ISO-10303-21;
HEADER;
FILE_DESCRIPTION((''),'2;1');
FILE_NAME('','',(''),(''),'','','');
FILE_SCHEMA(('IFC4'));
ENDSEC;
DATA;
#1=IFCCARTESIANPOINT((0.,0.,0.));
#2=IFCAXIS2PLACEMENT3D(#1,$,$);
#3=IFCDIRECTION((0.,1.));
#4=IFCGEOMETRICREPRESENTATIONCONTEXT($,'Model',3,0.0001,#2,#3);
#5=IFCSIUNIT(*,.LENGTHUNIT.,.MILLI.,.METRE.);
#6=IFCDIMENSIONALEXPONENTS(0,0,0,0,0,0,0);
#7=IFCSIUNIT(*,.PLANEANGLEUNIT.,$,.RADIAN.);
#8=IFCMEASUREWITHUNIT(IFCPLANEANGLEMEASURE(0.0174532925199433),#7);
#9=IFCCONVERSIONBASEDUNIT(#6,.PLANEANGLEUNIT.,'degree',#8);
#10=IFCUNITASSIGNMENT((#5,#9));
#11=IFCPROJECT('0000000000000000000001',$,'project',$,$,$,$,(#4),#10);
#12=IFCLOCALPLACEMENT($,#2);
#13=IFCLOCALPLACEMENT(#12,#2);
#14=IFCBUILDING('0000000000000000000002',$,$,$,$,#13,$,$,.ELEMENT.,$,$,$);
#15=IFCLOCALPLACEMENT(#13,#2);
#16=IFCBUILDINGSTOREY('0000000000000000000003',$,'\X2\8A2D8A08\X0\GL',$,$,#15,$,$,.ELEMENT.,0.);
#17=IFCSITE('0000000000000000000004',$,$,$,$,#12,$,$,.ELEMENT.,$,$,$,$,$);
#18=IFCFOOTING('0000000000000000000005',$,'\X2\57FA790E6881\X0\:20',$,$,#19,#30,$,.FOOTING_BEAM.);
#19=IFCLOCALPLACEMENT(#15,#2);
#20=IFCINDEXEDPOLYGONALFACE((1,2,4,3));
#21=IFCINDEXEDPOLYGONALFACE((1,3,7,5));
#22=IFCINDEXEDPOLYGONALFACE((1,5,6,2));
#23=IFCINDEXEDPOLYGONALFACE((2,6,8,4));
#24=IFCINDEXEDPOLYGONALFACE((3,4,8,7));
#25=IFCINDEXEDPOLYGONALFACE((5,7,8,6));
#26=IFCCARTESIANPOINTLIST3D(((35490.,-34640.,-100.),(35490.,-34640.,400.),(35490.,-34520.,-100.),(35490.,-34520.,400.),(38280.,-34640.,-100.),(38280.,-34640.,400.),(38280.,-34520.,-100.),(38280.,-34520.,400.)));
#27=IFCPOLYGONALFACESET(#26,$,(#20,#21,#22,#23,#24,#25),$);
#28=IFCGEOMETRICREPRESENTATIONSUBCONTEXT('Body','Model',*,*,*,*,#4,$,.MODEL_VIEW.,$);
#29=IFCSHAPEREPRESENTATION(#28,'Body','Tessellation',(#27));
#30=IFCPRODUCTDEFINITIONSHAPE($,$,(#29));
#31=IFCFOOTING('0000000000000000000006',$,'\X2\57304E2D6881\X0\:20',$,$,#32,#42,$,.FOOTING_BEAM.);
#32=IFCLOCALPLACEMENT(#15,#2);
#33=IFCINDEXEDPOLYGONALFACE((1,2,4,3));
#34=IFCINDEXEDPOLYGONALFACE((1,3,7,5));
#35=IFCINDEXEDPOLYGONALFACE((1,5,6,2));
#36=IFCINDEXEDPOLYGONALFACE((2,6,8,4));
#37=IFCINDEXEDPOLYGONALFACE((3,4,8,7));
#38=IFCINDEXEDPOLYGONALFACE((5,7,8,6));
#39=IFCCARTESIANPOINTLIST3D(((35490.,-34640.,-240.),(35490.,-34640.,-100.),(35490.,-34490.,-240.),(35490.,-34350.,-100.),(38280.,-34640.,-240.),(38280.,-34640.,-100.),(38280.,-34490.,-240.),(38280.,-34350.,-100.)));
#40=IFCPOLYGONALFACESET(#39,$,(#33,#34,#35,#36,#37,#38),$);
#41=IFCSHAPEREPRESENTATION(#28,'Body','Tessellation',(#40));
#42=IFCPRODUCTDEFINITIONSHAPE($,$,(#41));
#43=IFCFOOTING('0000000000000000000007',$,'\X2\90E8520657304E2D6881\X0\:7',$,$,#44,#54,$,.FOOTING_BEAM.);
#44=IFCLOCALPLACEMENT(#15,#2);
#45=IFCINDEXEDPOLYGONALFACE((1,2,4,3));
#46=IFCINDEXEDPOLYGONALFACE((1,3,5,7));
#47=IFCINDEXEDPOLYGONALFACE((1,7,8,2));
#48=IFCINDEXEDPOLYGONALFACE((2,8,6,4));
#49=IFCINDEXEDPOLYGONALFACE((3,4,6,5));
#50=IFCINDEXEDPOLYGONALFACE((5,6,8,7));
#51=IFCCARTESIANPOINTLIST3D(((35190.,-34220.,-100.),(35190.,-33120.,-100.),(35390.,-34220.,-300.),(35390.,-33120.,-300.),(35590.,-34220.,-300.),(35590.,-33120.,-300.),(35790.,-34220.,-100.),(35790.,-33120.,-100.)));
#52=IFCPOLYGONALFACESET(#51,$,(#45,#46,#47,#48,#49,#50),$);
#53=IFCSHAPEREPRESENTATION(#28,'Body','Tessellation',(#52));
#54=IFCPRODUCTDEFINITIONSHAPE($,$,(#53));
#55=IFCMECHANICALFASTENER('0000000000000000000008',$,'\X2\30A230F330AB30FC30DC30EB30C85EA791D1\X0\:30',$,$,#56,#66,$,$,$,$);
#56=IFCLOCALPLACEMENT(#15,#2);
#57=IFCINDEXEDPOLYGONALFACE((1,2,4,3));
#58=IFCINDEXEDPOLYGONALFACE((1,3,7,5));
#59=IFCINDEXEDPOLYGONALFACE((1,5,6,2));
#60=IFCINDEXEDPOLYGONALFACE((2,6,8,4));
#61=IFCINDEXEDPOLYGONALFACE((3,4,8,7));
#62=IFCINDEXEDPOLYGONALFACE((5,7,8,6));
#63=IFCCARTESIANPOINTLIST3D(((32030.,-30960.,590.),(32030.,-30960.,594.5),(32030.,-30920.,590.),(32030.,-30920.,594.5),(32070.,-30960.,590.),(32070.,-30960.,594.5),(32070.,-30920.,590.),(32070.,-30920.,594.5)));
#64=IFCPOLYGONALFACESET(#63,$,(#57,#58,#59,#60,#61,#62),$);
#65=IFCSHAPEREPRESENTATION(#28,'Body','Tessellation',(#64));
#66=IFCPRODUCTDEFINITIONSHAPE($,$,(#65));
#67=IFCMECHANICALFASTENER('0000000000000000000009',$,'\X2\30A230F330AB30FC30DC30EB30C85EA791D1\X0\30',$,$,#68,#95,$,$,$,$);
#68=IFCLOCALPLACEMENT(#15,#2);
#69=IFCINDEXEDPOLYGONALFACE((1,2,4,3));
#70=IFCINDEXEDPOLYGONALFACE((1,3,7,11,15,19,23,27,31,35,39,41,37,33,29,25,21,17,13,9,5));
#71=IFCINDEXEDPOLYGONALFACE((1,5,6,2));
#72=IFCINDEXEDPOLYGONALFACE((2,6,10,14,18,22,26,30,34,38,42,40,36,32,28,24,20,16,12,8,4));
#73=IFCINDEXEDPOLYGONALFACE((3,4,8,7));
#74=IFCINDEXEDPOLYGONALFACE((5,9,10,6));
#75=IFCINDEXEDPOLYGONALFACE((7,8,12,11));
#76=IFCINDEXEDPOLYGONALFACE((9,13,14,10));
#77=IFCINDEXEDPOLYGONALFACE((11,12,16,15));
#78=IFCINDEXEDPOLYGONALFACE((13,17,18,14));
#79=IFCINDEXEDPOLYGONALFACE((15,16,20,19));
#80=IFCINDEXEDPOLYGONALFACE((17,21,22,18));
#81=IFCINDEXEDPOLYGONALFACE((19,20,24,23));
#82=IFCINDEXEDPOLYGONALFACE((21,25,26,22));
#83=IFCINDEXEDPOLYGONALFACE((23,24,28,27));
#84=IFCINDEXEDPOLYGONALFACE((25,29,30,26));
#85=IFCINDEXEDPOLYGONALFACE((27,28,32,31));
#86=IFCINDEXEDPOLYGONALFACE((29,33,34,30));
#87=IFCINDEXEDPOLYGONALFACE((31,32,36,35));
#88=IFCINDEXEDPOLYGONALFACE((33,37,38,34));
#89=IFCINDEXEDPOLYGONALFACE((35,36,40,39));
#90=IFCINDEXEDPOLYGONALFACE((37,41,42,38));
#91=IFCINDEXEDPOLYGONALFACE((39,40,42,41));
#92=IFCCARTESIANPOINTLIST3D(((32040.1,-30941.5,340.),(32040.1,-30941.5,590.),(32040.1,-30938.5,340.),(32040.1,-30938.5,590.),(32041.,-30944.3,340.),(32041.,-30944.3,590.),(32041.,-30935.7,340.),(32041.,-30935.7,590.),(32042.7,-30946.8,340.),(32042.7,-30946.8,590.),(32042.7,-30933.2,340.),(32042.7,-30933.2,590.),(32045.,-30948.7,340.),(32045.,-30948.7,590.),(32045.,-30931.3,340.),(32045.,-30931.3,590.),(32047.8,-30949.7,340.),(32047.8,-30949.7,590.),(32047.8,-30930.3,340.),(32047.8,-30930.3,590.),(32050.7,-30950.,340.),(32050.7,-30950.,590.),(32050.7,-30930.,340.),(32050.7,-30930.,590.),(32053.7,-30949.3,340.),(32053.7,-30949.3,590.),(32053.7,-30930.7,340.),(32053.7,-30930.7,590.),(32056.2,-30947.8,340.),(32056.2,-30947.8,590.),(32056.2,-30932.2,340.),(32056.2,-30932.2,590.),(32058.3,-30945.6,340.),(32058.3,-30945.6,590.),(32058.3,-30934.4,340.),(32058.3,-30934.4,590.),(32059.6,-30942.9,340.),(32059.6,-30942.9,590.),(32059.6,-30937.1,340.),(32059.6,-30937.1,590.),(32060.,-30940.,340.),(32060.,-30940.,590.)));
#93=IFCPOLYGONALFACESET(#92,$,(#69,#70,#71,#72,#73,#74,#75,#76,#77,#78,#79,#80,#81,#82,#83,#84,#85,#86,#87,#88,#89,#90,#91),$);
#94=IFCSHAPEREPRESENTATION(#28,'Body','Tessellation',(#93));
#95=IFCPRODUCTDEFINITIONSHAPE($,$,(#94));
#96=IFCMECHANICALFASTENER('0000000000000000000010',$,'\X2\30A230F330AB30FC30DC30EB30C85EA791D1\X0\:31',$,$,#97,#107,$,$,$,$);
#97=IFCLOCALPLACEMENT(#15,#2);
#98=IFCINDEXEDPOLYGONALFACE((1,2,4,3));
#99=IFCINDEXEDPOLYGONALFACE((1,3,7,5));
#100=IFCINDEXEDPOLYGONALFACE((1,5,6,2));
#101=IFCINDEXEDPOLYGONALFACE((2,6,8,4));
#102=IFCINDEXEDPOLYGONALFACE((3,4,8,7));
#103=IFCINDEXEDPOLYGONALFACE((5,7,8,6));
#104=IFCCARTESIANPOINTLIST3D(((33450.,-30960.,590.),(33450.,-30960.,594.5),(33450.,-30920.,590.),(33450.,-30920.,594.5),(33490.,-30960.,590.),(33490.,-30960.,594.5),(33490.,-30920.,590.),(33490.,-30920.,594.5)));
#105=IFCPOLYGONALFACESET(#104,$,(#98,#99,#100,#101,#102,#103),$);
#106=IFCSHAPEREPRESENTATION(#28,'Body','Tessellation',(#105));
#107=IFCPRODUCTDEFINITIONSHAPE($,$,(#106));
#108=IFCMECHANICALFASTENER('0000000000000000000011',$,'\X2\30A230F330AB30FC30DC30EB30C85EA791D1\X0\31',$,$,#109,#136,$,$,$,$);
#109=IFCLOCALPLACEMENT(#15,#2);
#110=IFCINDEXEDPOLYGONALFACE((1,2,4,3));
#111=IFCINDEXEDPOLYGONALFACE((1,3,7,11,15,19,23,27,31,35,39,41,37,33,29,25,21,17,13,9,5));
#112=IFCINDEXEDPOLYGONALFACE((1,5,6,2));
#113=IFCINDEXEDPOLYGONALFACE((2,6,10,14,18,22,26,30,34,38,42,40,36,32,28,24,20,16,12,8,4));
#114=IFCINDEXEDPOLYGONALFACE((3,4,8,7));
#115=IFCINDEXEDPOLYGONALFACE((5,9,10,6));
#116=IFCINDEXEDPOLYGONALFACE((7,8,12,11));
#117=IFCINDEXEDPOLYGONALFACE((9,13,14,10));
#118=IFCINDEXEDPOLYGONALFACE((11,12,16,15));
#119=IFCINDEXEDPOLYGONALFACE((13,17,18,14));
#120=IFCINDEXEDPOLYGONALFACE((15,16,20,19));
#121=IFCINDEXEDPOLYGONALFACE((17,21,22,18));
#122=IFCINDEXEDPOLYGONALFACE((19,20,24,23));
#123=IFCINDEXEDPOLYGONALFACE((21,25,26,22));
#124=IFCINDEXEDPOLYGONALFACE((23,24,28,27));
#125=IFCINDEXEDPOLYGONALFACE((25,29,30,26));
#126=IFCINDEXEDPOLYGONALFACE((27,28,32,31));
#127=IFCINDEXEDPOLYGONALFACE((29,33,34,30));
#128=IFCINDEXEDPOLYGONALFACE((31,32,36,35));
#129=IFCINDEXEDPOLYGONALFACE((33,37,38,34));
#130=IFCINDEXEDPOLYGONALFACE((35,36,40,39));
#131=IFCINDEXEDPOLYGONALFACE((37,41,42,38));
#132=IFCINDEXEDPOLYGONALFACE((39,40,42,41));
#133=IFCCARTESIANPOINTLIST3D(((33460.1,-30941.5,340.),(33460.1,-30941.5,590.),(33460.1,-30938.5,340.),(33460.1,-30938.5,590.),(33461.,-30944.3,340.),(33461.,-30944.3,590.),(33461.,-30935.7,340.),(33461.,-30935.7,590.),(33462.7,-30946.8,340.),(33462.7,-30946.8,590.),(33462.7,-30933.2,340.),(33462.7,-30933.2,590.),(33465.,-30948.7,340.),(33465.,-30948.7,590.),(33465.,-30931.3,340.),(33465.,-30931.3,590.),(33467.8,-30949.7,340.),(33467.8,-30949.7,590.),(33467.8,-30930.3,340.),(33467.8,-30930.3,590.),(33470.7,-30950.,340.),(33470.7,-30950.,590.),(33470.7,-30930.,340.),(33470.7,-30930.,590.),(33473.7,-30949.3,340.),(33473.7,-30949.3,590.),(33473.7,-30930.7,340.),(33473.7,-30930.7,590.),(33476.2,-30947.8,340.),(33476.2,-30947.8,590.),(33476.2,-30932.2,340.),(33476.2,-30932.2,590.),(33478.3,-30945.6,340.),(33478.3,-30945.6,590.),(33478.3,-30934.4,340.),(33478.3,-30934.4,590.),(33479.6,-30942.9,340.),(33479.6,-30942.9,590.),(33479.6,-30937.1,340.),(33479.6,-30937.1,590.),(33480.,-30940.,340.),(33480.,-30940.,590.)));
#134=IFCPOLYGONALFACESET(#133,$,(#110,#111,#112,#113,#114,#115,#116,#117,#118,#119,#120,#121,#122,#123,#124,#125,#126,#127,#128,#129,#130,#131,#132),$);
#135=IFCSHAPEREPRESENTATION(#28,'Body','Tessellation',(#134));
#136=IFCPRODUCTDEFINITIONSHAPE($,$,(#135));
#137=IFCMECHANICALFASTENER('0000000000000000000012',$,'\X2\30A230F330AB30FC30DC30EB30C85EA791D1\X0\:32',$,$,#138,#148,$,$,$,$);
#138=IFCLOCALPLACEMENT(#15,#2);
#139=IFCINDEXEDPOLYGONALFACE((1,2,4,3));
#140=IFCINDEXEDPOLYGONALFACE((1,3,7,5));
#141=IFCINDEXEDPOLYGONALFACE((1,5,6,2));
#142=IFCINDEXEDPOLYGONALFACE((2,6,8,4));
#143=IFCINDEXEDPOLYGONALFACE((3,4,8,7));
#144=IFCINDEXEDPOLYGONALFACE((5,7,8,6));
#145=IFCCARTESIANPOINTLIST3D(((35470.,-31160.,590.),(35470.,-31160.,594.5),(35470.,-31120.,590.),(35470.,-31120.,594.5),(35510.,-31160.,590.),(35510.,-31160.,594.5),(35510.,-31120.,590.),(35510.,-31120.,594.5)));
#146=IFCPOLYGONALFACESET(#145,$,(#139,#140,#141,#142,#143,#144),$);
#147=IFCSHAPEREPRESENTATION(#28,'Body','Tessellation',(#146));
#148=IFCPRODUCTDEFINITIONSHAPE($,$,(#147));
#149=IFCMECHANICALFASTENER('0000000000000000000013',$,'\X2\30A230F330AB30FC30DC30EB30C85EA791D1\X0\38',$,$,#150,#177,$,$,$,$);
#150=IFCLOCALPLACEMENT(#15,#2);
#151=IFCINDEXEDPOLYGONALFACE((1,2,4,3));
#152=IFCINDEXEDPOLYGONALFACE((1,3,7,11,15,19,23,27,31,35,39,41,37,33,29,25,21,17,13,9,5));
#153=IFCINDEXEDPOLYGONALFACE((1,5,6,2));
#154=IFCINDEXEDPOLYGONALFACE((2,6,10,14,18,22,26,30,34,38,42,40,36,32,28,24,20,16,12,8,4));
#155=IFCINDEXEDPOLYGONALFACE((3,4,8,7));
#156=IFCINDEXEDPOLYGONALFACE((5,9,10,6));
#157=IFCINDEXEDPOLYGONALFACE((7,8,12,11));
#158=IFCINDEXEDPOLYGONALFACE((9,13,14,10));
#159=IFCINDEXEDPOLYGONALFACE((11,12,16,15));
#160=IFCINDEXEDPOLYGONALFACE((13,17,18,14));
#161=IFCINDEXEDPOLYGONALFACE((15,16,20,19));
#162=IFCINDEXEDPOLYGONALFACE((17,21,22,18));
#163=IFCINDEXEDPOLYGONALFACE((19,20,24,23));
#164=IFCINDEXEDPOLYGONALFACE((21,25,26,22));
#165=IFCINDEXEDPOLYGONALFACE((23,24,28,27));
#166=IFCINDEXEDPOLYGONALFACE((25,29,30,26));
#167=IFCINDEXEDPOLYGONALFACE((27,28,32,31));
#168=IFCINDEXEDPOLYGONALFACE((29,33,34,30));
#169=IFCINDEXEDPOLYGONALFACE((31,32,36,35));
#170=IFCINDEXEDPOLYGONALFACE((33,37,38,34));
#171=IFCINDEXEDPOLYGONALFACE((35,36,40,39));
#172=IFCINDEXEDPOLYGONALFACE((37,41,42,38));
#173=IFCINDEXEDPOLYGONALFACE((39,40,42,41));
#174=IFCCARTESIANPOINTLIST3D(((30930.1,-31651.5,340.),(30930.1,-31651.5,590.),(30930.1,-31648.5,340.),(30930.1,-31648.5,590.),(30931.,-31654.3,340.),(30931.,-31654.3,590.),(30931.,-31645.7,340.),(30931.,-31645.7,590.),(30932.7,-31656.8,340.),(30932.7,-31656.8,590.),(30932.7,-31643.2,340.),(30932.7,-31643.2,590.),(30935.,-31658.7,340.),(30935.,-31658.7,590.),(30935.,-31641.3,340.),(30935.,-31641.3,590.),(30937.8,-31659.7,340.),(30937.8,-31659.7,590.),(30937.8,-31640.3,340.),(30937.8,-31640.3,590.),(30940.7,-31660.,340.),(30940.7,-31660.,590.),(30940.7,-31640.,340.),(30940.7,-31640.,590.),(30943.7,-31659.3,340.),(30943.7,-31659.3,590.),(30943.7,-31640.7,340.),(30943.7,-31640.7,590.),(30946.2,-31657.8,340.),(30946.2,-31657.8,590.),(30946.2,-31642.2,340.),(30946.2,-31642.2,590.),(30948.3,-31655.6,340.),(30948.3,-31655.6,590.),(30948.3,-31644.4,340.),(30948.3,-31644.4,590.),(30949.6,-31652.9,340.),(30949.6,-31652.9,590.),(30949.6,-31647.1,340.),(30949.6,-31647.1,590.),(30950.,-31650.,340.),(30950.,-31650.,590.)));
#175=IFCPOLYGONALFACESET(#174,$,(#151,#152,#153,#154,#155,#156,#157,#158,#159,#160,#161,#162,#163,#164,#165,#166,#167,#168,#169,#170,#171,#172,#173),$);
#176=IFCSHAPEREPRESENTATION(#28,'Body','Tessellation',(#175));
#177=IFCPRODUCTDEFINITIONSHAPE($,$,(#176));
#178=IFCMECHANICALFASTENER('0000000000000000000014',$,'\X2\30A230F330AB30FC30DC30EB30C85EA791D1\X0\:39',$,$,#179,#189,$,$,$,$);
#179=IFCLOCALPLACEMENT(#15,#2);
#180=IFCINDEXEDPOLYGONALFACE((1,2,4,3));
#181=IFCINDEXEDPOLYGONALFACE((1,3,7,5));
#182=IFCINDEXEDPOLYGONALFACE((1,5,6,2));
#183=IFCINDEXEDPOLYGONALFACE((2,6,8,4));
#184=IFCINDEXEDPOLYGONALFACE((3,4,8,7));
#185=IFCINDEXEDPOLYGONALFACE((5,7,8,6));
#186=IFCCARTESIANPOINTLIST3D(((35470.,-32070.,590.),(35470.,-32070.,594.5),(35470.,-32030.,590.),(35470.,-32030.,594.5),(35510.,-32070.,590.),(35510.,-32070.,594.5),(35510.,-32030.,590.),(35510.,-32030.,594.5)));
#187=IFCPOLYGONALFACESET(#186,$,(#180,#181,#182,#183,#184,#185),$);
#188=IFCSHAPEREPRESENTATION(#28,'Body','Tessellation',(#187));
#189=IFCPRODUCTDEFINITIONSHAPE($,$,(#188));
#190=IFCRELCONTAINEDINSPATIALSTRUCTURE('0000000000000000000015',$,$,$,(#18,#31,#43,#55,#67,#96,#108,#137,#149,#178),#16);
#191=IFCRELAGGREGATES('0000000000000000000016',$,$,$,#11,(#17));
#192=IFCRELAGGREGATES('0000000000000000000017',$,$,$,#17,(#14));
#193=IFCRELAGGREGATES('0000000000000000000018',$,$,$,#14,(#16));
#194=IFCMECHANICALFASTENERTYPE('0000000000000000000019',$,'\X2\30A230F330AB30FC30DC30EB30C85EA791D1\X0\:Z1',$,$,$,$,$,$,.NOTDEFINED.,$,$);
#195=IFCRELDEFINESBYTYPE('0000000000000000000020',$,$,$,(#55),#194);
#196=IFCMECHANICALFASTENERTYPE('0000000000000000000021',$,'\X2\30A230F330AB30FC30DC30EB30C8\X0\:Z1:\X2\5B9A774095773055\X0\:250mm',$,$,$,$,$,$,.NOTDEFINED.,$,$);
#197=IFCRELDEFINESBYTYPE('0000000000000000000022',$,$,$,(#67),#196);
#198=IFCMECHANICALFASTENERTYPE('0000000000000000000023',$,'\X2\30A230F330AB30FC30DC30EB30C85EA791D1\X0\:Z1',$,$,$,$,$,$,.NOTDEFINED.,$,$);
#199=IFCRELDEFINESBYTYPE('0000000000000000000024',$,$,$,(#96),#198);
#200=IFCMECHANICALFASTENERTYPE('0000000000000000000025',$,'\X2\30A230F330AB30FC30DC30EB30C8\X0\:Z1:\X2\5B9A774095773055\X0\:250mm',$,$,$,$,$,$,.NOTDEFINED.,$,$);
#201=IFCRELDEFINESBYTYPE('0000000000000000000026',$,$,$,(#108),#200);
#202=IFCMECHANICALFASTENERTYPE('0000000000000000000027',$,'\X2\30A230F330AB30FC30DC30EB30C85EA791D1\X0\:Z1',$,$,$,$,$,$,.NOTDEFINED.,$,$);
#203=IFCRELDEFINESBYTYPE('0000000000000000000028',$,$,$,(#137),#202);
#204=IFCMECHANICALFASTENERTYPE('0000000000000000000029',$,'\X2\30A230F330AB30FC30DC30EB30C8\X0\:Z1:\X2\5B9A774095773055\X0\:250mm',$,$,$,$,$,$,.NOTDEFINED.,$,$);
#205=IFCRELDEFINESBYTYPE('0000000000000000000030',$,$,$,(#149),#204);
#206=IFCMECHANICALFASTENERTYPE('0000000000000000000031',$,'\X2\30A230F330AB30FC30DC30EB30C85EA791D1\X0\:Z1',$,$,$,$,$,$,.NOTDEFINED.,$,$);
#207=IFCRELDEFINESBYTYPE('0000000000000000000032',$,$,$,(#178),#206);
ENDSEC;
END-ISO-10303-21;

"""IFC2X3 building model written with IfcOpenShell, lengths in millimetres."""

from ifc_helpers import new_model, entity, si_unit, converted_unit, direction, frame, origin, origin_with_axes, origin_2d, place, context, subcontext, project, spatial, polyline, rectangle, circle, outline, extrude, type_object, element, save


model = new_model("IFC2X3")

# Units and contexts
model_context = context("Model", 3, precision=0.0001, world=origin(), true_north=direction((0.0, 1.0)))
body_context = subcontext(model_context, "Body", "Model", "MODEL_VIEW")
ifc_project = project(units=[si_unit("LENGTHUNIT", "METRE", prefix="MILLI"), converted_unit("PLANEANGLEUNIT", "degree", entity("IfcPlaneAngleMeasure", 0.0174532925199433), si_unit("PLANEANGLEUNIT", "RADIAN"), dimensions=[0, 0, 0, 0, 0, 0, 0])], contexts=[model_context])

# Site, building, storey
site_placement = place(None, origin())
site = spatial("IfcSite", under=ifc_project, at=site_placement, CompositionType="ELEMENT")
building_placement = place(site_placement, origin())
building = spatial("IfcBuilding", under=site, at=building_placement, CompositionType="ELEMENT")
storey_placement = place(building_placement, origin())
storey = spatial("IfcBuildingStorey", under=building, at=storey_placement, Name="設計GL", CompositionType="ELEMENT", Elevation=0.0)

# Footings
footing_1_placement = place(storey_placement, frame((35490.0, -34580.0, 150.0), z_axis=(1.0, 0.0, 0.0), x_axis=(0.0, 1.0, 0.0)))
element("IfcFooting", 1, at=footing_1_placement, inside=storey, Name="基礎梁:20", PredefinedType="FOOTING_BEAM", context=body_context, shape_type="SolidModel", body=[
    extrude(rectangle(XDim=120.0, YDim=500.0, at=origin_2d()), origin_with_axes(), (0.0, 0.0, 1.0), 2790.0),
])
footing_2_placement = place(storey_placement, frame((35490.0, -34640.0, -240.0), z_axis=(1.0, 0.0, 0.0), x_axis=(0.0, 1.0, 0.0)))
element("IfcFooting", 2, at=footing_2_placement, inside=storey, Name="地中梁:20", PredefinedType="FOOTING_BEAM", context=body_context, shape_type="SweptSolid", body=[
    extrude(outline(polyline([(0.0, 0.0, 0.0), (150.0, 0.0, 0.0), (290.0, 140.0, 0.0), (0.0, 140.0, 0.0), (0.0, 0.0, 0.0)])), origin_with_axes(), (0.0, 0.0, 1.0), 2790.0),
])
footing_3_placement = place(storey_placement, frame((35490.0, -33120.0, -300.0), z_axis=(0.0, -1.0, 0.0), x_axis=(1.0, 0.0, 0.0)))
element("IfcFooting", 3, at=footing_3_placement, inside=storey, Name="部分地中梁:7", PredefinedType="FOOTING_BEAM", context=body_context, shape_type="SweptSolid", body=[
    extrude(outline(polyline([(-100.0, 0.0, 0.0), (100.0, 0.0, 0.0), (300.0, 200.0, 0.0), (-300.0, 200.0, 0.0), (-100.0, 0.0, 0.0)])), origin_with_axes(), (0.0, 0.0, 1.0), 1100.0),
])

# Mechanical fasteners
mechanical_fastener_type_1 = type_object("IfcMechanicalFastenerType", Name="アンカーボルト座金:Z1")
mechanical_fastener_1_placement = place(storey_placement, frame((32050.0, -30940.0, 590.0)))
element("IfcMechanicalFastener", 4, at=mechanical_fastener_1_placement, inside=storey, type_object=mechanical_fastener_type_1, Name="アンカーボルト座金:30", context=body_context, shape_type="SweptSolid", body=[
    extrude(rectangle(XDim=40.0, YDim=40.0, at=origin_2d()), origin_with_axes(), (0.0, 0.0, 1.0), 4.5),
])
mechanical_fastener_type_2 = type_object("IfcMechanicalFastenerType", Name="アンカーボルト:Z1:定着長さ:250mm")
mechanical_fastener_2_placement = place(storey_placement, frame((32050.0, -30940.0, 340.0)))
element("IfcMechanicalFastener", 5, at=mechanical_fastener_2_placement, inside=storey, type_object=mechanical_fastener_type_2, Name="アンカーボルト座金30", context=body_context, shape_type="SweptSolid", body=[
    extrude(circle(Radius=10.0, at=origin_2d()), origin_with_axes(), (0.0, 0.0, 1.0), 250.0),
])
mechanical_fastener_type_3 = type_object("IfcMechanicalFastenerType", Name="アンカーボルト座金:Z1")
mechanical_fastener_3_placement = place(storey_placement, frame((33470.0, -30940.0, 590.0)))
element("IfcMechanicalFastener", 6, at=mechanical_fastener_3_placement, inside=storey, type_object=mechanical_fastener_type_3, Name="アンカーボルト座金:31", context=body_context, shape_type="SweptSolid", body=[
    extrude(rectangle(XDim=40.0, YDim=40.0, at=origin_2d()), origin_with_axes(), (0.0, 0.0, 1.0), 4.5),
])
mechanical_fastener_type_4 = type_object("IfcMechanicalFastenerType", Name="アンカーボルト:Z1:定着長さ:250mm")
mechanical_fastener_4_placement = place(storey_placement, frame((33470.0, -30940.0, 340.0)))
element("IfcMechanicalFastener", 7, at=mechanical_fastener_4_placement, inside=storey, type_object=mechanical_fastener_type_4, Name="アンカーボルト座金31", context=body_context, shape_type="SweptSolid", body=[
    extrude(circle(Radius=10.0, at=origin_2d()), origin_with_axes(), (0.0, 0.0, 1.0), 250.0),
])
mechanical_fastener_type_5 = type_object("IfcMechanicalFastenerType", Name="アンカーボルト座金:Z1")
mechanical_fastener_5_placement = place(storey_placement, frame((35490.0, -31140.0, 590.0)))
element("IfcMechanicalFastener", 8, at=mechanical_fastener_5_placement, inside=storey, type_object=mechanical_fastener_type_5, Name="アンカーボルト座金:32", context=body_context, shape_type="SweptSolid", body=[
    extrude(rectangle(XDim=40.0, YDim=40.0, at=origin_2d()), origin_with_axes(), (0.0, 0.0, 1.0), 4.5),
])
mechanical_fastener_type_6 = type_object("IfcMechanicalFastenerType", Name="アンカーボルト:Z1:定着長さ:250mm")
mechanical_fastener_6_placement = place(storey_placement, frame((30940.0, -31650.0, 340.0)))
element("IfcMechanicalFastener", 9, at=mechanical_fastener_6_placement, inside=storey, type_object=mechanical_fastener_type_6, Name="アンカーボルト座金38", context=body_context, shape_type="SweptSolid", body=[
    extrude(circle(Radius=10.0, at=origin_2d()), origin_with_axes(), (0.0, 0.0, 1.0), 250.0),
])
mechanical_fastener_type_7 = type_object("IfcMechanicalFastenerType", Name="アンカーボルト座金:Z1")
mechanical_fastener_7_placement = place(storey_placement, frame((35490.0, -32050.0, 590.0)))
element("IfcMechanicalFastener", 10, at=mechanical_fastener_7_placement, inside=storey, type_object=mechanical_fastener_type_7, Name="アンカーボルト座金:39", context=body_context, shape_type="SweptSolid", body=[
    extrude(rectangle(XDim=40.0, YDim=40.0, at=origin_2d()), origin_with_axes(), (0.0, 0.0, 1.0), 4.5),
])

save(model, "model.ifc")
